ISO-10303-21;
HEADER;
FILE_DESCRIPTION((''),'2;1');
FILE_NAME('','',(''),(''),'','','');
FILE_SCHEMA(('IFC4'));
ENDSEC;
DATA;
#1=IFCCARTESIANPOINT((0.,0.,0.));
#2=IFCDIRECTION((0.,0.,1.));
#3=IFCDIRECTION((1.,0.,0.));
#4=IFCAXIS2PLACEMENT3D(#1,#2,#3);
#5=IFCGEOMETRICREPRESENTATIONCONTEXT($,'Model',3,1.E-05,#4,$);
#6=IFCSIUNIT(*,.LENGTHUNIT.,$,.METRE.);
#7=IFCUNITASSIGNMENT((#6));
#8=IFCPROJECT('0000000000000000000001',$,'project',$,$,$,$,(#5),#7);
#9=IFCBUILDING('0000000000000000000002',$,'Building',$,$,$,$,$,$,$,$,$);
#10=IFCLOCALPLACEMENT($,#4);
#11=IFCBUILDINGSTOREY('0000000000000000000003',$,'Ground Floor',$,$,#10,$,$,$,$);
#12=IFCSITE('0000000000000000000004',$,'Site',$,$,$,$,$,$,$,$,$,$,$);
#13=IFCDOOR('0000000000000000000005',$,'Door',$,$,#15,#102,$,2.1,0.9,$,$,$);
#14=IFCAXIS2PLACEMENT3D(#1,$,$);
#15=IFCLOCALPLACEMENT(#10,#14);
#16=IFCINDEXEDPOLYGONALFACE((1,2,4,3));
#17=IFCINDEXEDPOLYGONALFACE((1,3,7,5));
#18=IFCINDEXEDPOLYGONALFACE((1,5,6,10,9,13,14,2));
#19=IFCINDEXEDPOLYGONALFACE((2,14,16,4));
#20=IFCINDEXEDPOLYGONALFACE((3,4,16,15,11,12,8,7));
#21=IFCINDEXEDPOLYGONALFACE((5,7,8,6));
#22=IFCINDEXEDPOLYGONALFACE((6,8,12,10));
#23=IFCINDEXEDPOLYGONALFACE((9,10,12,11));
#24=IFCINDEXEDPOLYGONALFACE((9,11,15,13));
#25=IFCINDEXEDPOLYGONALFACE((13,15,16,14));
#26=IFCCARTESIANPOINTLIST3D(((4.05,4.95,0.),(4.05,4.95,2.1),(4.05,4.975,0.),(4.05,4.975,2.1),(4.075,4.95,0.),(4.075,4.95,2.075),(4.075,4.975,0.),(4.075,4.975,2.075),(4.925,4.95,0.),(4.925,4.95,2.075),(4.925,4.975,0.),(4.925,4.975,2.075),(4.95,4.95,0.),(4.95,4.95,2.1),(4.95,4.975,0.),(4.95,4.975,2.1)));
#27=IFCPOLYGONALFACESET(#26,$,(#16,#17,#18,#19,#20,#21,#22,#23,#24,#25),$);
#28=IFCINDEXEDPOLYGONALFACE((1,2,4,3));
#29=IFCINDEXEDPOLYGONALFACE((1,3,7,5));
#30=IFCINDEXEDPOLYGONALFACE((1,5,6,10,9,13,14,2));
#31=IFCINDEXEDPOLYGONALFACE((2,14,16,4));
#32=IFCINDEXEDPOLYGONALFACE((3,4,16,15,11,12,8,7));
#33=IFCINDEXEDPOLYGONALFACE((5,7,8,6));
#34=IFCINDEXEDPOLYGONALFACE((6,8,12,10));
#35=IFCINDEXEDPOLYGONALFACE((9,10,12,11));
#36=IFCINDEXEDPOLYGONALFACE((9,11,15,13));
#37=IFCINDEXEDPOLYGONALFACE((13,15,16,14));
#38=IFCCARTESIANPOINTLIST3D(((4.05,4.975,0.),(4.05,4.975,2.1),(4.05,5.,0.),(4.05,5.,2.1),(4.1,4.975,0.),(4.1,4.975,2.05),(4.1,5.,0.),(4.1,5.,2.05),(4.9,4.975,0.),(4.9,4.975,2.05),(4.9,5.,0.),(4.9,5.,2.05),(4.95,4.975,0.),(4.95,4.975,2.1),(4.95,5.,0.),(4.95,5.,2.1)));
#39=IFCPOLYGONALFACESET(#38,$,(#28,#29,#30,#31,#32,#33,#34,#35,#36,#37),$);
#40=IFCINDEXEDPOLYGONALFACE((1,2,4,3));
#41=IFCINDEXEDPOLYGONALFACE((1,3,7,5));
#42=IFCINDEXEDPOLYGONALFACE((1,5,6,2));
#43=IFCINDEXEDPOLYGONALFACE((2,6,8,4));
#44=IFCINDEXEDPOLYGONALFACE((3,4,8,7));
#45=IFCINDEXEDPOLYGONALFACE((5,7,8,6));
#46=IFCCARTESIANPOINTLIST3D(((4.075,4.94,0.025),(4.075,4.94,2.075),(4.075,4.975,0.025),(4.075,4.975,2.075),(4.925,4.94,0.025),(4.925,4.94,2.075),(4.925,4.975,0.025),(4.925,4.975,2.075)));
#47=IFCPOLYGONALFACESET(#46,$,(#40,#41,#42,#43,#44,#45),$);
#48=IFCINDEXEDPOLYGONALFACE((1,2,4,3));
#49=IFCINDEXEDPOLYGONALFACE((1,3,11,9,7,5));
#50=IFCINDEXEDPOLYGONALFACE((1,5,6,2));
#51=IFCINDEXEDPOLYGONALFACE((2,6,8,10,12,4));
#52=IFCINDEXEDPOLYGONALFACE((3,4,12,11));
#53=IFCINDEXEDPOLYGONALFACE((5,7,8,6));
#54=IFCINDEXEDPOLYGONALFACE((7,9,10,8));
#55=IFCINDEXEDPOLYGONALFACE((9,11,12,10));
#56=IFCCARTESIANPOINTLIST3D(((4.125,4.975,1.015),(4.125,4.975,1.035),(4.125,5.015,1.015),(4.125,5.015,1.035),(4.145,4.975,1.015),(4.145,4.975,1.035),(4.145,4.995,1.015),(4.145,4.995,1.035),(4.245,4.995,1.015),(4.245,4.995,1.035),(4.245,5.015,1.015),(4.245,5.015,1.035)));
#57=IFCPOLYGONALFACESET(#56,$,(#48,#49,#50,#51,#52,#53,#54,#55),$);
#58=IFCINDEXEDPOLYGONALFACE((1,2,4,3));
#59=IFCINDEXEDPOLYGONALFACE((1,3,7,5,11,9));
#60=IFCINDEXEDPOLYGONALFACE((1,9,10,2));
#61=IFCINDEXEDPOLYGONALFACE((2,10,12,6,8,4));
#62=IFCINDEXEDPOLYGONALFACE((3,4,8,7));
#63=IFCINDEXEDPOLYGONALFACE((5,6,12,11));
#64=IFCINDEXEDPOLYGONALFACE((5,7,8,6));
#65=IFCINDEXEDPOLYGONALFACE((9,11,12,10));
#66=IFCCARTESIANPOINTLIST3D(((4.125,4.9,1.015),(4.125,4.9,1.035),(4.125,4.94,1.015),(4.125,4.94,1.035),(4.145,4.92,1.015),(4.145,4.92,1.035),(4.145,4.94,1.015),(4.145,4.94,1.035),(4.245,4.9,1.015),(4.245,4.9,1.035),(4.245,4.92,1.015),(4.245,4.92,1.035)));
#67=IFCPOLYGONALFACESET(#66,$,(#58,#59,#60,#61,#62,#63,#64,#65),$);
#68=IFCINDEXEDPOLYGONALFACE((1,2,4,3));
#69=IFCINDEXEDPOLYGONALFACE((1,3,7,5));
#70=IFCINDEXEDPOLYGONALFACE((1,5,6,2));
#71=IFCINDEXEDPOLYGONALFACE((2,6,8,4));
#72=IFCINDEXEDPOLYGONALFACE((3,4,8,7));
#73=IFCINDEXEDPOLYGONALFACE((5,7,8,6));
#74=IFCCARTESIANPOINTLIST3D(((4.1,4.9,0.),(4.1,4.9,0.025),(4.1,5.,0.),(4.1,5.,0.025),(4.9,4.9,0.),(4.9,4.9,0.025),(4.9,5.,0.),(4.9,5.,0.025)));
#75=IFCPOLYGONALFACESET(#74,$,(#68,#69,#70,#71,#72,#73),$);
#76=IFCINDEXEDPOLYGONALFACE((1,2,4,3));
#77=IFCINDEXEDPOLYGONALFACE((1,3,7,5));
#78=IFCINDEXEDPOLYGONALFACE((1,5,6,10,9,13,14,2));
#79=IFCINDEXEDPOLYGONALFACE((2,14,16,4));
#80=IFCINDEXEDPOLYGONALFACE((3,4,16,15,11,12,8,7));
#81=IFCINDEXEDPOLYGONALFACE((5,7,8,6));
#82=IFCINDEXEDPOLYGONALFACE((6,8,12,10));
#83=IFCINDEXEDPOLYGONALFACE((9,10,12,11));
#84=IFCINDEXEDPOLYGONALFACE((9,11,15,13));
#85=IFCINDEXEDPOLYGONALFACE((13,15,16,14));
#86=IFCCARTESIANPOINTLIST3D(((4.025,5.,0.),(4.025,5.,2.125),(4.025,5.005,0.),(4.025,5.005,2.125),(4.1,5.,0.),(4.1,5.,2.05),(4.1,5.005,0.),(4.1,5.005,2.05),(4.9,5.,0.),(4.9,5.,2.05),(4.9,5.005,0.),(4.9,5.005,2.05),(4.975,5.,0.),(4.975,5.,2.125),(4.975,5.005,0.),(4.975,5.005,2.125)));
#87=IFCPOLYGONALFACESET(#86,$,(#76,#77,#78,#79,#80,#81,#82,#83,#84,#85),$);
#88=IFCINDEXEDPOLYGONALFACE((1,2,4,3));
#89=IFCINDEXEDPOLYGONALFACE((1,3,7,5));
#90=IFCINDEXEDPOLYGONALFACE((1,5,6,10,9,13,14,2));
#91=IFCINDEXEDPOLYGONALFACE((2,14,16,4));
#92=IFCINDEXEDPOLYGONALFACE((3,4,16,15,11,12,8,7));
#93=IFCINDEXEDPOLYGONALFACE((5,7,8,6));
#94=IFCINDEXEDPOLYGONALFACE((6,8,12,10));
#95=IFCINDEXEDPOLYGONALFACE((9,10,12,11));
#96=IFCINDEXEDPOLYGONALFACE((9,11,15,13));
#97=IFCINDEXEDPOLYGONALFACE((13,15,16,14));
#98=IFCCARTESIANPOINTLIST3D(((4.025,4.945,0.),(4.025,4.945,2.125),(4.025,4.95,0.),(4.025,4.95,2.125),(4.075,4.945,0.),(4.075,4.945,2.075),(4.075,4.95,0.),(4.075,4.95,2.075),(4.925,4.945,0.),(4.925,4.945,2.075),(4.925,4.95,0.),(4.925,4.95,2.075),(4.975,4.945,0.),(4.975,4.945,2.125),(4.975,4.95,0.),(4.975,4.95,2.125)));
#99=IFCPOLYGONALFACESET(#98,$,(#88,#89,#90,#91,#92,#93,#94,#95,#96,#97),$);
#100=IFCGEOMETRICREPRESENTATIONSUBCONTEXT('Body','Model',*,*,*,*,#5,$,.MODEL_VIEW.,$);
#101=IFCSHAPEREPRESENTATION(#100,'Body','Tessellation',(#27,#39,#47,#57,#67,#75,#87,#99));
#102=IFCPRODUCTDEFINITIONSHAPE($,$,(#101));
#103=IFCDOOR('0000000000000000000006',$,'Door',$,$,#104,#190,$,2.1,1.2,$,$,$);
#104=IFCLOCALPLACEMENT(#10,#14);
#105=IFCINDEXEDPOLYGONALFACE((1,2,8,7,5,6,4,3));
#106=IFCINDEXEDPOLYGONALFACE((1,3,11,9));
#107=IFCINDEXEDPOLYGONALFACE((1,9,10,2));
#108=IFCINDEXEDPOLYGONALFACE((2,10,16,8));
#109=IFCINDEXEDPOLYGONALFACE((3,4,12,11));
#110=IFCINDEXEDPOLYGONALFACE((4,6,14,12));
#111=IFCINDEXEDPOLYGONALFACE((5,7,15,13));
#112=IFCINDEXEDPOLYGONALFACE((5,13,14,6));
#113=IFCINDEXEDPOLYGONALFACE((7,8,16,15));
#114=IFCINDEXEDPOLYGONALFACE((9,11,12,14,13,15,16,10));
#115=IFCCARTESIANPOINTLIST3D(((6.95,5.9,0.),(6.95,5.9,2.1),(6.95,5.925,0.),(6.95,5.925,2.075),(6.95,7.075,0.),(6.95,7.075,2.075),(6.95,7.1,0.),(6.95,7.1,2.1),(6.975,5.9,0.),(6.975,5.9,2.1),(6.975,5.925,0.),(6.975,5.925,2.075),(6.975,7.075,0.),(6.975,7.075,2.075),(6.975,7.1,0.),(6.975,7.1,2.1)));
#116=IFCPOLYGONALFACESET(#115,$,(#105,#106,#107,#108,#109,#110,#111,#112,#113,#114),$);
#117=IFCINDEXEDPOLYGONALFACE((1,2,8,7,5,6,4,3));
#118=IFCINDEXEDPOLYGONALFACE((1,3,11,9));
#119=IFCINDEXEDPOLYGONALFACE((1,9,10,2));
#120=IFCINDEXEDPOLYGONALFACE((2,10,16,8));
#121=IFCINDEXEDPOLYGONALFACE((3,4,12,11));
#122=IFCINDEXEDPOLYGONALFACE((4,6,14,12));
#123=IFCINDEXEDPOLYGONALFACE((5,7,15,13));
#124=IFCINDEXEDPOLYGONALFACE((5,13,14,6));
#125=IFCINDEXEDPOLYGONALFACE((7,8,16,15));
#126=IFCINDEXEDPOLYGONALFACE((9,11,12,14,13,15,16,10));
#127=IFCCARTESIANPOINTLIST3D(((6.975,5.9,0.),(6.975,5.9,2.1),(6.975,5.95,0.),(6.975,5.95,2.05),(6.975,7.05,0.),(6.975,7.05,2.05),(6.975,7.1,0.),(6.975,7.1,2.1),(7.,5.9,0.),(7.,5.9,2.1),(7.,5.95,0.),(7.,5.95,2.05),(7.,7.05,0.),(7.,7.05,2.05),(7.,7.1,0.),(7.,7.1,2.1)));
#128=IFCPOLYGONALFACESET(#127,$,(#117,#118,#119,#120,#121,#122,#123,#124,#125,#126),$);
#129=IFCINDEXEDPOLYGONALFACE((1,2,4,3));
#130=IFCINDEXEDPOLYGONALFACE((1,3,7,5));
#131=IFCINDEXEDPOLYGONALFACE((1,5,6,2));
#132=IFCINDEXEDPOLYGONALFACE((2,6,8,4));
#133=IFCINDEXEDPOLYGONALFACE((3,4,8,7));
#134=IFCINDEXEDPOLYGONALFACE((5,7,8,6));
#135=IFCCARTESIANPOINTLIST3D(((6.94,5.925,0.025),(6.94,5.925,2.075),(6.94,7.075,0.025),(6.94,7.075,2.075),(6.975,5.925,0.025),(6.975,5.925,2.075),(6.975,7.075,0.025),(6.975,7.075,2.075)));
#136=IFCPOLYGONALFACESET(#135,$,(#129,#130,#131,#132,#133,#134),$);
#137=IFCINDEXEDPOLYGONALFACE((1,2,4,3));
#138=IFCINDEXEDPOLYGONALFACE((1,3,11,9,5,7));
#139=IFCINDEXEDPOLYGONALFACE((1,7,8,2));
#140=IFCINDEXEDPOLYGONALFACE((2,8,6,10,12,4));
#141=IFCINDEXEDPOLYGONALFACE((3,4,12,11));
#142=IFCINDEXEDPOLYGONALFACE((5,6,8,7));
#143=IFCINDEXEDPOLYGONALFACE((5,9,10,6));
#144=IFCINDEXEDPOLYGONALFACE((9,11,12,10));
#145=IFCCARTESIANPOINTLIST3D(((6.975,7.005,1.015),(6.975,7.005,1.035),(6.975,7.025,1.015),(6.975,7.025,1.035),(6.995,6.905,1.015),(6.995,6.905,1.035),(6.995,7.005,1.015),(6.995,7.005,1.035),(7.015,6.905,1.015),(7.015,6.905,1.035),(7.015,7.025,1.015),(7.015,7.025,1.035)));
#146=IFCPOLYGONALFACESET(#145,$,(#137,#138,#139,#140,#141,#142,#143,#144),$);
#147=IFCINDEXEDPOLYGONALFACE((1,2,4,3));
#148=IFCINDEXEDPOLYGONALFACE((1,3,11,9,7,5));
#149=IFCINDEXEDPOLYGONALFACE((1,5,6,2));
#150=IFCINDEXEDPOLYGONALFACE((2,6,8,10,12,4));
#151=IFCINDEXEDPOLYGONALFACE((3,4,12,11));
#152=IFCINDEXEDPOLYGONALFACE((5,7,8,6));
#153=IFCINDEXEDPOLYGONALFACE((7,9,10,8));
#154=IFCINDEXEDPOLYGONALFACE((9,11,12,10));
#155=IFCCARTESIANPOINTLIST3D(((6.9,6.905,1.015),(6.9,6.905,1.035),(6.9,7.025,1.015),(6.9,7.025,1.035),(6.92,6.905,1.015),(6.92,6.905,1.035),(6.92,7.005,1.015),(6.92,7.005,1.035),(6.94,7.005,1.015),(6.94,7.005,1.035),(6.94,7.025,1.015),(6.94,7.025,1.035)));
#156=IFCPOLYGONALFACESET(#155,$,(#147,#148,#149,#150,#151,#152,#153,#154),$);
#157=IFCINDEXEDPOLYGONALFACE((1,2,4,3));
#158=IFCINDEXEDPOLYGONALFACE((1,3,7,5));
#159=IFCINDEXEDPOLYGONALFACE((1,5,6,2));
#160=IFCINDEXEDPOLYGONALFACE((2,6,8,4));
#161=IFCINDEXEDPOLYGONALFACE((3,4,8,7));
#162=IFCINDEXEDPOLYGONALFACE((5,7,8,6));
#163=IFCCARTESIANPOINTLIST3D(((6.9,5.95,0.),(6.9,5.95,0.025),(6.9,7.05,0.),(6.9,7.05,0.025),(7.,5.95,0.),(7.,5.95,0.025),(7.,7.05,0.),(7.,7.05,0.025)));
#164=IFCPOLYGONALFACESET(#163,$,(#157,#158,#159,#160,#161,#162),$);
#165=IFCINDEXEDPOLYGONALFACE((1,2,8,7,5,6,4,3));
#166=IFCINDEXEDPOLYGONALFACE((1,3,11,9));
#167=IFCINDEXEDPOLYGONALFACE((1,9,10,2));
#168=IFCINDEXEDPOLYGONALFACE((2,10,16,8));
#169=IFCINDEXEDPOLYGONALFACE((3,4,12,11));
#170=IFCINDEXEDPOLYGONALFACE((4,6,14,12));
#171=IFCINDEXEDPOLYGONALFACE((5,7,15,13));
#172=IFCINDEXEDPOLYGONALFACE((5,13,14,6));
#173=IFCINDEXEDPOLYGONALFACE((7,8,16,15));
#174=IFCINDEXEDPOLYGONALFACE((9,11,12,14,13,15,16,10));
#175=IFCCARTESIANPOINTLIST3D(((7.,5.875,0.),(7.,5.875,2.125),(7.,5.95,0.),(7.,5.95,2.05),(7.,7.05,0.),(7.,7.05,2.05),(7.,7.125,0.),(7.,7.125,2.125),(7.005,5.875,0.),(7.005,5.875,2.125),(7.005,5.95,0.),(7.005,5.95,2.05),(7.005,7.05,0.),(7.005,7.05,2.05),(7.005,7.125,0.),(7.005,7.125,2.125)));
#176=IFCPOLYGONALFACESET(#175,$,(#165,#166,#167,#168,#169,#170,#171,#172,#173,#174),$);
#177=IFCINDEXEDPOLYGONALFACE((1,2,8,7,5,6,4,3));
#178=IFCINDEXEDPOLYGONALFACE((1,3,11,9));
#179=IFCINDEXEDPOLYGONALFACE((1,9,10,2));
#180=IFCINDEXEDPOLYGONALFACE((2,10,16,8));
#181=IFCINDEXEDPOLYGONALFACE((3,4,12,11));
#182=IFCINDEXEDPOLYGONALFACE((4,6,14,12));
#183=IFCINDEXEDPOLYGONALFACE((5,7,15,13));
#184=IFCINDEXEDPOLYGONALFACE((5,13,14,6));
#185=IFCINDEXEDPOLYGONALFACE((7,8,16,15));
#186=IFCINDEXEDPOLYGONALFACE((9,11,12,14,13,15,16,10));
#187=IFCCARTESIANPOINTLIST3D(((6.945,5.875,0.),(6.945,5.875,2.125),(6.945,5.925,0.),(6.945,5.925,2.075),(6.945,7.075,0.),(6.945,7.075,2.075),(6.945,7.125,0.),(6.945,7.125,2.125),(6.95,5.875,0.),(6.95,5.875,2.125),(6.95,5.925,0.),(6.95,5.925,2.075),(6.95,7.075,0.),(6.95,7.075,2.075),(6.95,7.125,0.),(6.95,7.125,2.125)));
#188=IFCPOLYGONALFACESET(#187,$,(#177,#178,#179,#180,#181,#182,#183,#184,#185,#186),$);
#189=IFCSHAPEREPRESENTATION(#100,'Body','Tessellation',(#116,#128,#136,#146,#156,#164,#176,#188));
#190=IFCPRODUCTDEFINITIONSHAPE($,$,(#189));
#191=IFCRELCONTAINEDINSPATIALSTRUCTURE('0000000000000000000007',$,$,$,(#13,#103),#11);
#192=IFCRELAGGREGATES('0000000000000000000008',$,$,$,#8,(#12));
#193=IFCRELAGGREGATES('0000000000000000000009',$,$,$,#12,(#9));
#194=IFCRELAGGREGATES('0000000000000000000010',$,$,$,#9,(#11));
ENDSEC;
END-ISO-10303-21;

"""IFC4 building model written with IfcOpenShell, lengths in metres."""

from ifc_helpers import new_model, si_unit, frame, origin_with_axes, place, context, subcontext, project, spatial, line, indexed_curve, outline, extrude, element, save


model = new_model("IFC4")

# Units and contexts
model_context = context("Model", 3, precision=1e-05, world=origin_with_axes())
body_context = subcontext(model_context, "Body", "Model", "MODEL_VIEW")
ifc_project = project(units=[si_unit("LENGTHUNIT", "METRE")], contexts=[model_context])

# Site, building, storey
site = spatial("IfcSite", under=ifc_project, Name="Site")
building = spatial("IfcBuilding", under=site, Name="Building")
storey_placement = place(None, origin_with_axes())
storey = spatial("IfcBuildingStorey", under=building, at=storey_placement, Name="Ground Floor")

# Doors
door_1_placement = place(storey_placement, frame((4.95, 5.0, 0.0), z_axis=(0.0, 0.0, 1.0), x_axis=(-1.0, 0.0, 0.0)))
element("IfcDoor", 1, at=door_1_placement, inside=storey, Name="Door", OverallHeight=2.1, OverallWidth=0.9, context=body_context, shape_type="SweptSolid", body=[
    extrude(outline(indexed_curve([(0.0, 0.0), (0.0, 2.1), (0.9, 2.1), (0.9, 0.0), (0.875, 0.0), (0.875, 2.075), (0.025, 2.075), (0.025, 0.0)], segments=[line(1, 2, 3, 4, 5, 6, 7, 8, 1)])), frame((0.0, 0.025, 0.0), z_axis=(0.0, -1.0, 0.0), x_axis=(1.0, 0.0, 0.0)), (0.0, 0.0, -1.0), 0.025),
    extrude(outline(indexed_curve([(0.0, 0.0), (0.0, 2.1), (0.9, 2.1), (0.9, 0.0), (0.85, 0.0), (0.85, 2.05), (0.05, 2.05), (0.05, 0.0)], segments=[line(1, 2, 3, 4, 5, 6, 7, 8, 1)])), frame((0.0, 0.0, 0.0), z_axis=(0.0, -1.0, 0.0), x_axis=(1.0, 0.0, 0.0)), (0.0, 0.0, -1.0), 0.025),
    extrude(outline(indexed_curve([(0.0, 0.0), (0.85, 0.0), (0.85, 0.035), (0.0, 0.035)], segments=[line(1, 2, 3, 4, 1)])), frame((0.025, 0.025, 0.025), z_axis=(0.0, 0.0, 1.0), x_axis=(1.0, 0.0, 0.0)), (0.0, 0.0, 1.0), 2.05),
    extrude(outline(indexed_curve([(0.0, 0.0), (0.0, -0.04), (-0.12, -0.04), (-0.12, -0.02), (-0.02, -0.02), (-0.02, 0.0)], segments=[line(1, 2, 3, 4, 5, 6, 1)])), frame((0.825, 0.025, 1.015), z_axis=(0.0, 0.0, 1.0), x_axis=(1.0, 0.0, 0.0)), (0.0, 0.0, 1.0), 0.02),
    extrude(outline(indexed_curve([(0.0, 0.0), (0.0, 0.04), (-0.12, 0.04), (-0.12, 0.02), (-0.02, 0.02), (-0.02, 0.0)], segments=[line(1, 2, 3, 4, 5, 6, 1)])), frame((0.825, 0.06, 1.015), z_axis=(0.0, 0.0, 1.0), x_axis=(1.0, 0.0, 0.0)), (0.0, 0.0, 1.0), 0.02),
    extrude(outline(indexed_curve([(0.0, 0.0), (0.8, 0.0), (0.8, 0.1), (0.0, 0.1)], segments=[line(1, 2, 3, 4, 1)])), frame((0.05, 0.0, 0.0), z_axis=(0.0, 0.0, 1.0), x_axis=(1.0, 0.0, 0.0)), (0.0, 0.0, 1.0), 0.025),
    extrude(outline(indexed_curve([(0.0, 0.0), (0.0, 2.125), (0.95, 2.125), (0.95, 0.0), (0.875, 0.0), (0.875, 2.05), (0.075, 2.05), (0.075, 0.0)], segments=[line(1, 2, 3, 4, 5, 6, 7, 8, 1)])), frame((-0.025, -0.005, 0.0), z_axis=(0.0, -1.0, 0.0), x_axis=(1.0, 0.0, 0.0)), (0.0, 0.0, -1.0), 0.005),
    extrude(outline(indexed_curve([(0.0, 0.0), (0.0, 2.125), (0.95, 2.125), (0.95, 0.0), (0.9, 0.0), (0.9, 2.075), (0.05, 2.075), (0.05, 0.0)], segments=[line(1, 2, 3, 4, 5, 6, 7, 8, 1)])), frame((-0.025, 0.05, 0.0), z_axis=(0.0, -1.0, 0.0), x_axis=(1.0, 0.0, 0.0)), (0.0, 0.0, -1.0), 0.005),
])
door_2_placement = place(storey_placement, frame((7.0, 5.9, 0.0), z_axis=(0.0, 0.0, 1.0), x_axis=(0.0, 1.0, 0.0)))
element("IfcDoor", 2, at=door_2_placement, inside=storey, Name="Door", OverallHeight=2.1, OverallWidth=1.2, context=body_context, shape_type="SweptSolid", body=[
    extrude(outline(indexed_curve([(0.0, 0.0), (0.0, 2.1), (1.2, 2.1), (1.2, 0.0), (1.175, 0.0), (1.175, 2.075), (0.025, 2.075), (0.025, 0.0)], segments=[line(1, 2, 3, 4, 5, 6, 7, 8, 1)])), frame((0.0, 0.025, 0.0), z_axis=(0.0, -1.0, 0.0), x_axis=(1.0, 0.0, 0.0)), (0.0, 0.0, -1.0), 0.025),
    extrude(outline(indexed_curve([(0.0, 0.0), (0.0, 2.1), (1.2, 2.1), (1.2, 0.0), (1.15, 0.0), (1.15, 2.05), (0.05, 2.05), (0.05, 0.0)], segments=[line(1, 2, 3, 4, 5, 6, 7, 8, 1)])), frame((0.0, 0.0, 0.0), z_axis=(0.0, -1.0, 0.0), x_axis=(1.0, 0.0, 0.0)), (0.0, 0.0, -1.0), 0.025),
    extrude(outline(indexed_curve([(0.0, 0.0), (1.15, 0.0), (1.15, 0.035), (0.0, 0.035)], segments=[line(1, 2, 3, 4, 1)])), frame((0.025, 0.025, 0.025), z_axis=(0.0, 0.0, 1.0), x_axis=(1.0, 0.0, 0.0)), (0.0, 0.0, 1.0), 2.05),
    extrude(outline(indexed_curve([(0.0, 0.0), (0.0, -0.04), (-0.12, -0.04), (-0.12, -0.02), (-0.02, -0.02), (-0.02, 0.0)], segments=[line(1, 2, 3, 4, 5, 6, 1)])), frame((1.125, 0.025, 1.015), z_axis=(0.0, 0.0, 1.0), x_axis=(1.0, 0.0, 0.0)), (0.0, 0.0, 1.0), 0.02),
    extrude(outline(indexed_curve([(0.0, 0.0), (0.0, 0.04), (-0.12, 0.04), (-0.12, 0.02), (-0.02, 0.02), (-0.02, 0.0)], segments=[line(1, 2, 3, 4, 5, 6, 1)])), frame((1.125, 0.06, 1.015), z_axis=(0.0, 0.0, 1.0), x_axis=(1.0, 0.0, 0.0)), (0.0, 0.0, 1.0), 0.02),
    extrude(outline(indexed_curve([(0.0, 0.0), (1.1, 0.0), (1.1, 0.1), (0.0, 0.1)], segments=[line(1, 2, 3, 4, 1)])), frame((0.05, 0.0, 0.0), z_axis=(0.0, 0.0, 1.0), x_axis=(1.0, 0.0, 0.0)), (0.0, 0.0, 1.0), 0.025),
    extrude(outline(indexed_curve([(0.0, 0.0), (0.0, 2.125), (1.25, 2.125), (1.25, 0.0), (1.175, 0.0), (1.175, 2.05), (0.075, 2.05), (0.075, 0.0)], segments=[line(1, 2, 3, 4, 5, 6, 7, 8, 1)])), frame((-0.025, -0.005, 0.0), z_axis=(0.0, -1.0, 0.0), x_axis=(1.0, 0.0, 0.0)), (0.0, 0.0, -1.0), 0.005),
    extrude(outline(indexed_curve([(0.0, 0.0), (0.0, 2.125), (1.25, 2.125), (1.25, 0.0), (1.2, 0.0), (1.2, 2.075), (0.05, 2.075), (0.05, 0.0)], segments=[line(1, 2, 3, 4, 5, 6, 7, 8, 1)])), frame((-0.025, 0.05, 0.0), z_axis=(0.0, -1.0, 0.0), x_axis=(1.0, 0.0, 0.0)), (0.0, 0.0, -1.0), 0.005),
])

save(model, "model.ifc")
